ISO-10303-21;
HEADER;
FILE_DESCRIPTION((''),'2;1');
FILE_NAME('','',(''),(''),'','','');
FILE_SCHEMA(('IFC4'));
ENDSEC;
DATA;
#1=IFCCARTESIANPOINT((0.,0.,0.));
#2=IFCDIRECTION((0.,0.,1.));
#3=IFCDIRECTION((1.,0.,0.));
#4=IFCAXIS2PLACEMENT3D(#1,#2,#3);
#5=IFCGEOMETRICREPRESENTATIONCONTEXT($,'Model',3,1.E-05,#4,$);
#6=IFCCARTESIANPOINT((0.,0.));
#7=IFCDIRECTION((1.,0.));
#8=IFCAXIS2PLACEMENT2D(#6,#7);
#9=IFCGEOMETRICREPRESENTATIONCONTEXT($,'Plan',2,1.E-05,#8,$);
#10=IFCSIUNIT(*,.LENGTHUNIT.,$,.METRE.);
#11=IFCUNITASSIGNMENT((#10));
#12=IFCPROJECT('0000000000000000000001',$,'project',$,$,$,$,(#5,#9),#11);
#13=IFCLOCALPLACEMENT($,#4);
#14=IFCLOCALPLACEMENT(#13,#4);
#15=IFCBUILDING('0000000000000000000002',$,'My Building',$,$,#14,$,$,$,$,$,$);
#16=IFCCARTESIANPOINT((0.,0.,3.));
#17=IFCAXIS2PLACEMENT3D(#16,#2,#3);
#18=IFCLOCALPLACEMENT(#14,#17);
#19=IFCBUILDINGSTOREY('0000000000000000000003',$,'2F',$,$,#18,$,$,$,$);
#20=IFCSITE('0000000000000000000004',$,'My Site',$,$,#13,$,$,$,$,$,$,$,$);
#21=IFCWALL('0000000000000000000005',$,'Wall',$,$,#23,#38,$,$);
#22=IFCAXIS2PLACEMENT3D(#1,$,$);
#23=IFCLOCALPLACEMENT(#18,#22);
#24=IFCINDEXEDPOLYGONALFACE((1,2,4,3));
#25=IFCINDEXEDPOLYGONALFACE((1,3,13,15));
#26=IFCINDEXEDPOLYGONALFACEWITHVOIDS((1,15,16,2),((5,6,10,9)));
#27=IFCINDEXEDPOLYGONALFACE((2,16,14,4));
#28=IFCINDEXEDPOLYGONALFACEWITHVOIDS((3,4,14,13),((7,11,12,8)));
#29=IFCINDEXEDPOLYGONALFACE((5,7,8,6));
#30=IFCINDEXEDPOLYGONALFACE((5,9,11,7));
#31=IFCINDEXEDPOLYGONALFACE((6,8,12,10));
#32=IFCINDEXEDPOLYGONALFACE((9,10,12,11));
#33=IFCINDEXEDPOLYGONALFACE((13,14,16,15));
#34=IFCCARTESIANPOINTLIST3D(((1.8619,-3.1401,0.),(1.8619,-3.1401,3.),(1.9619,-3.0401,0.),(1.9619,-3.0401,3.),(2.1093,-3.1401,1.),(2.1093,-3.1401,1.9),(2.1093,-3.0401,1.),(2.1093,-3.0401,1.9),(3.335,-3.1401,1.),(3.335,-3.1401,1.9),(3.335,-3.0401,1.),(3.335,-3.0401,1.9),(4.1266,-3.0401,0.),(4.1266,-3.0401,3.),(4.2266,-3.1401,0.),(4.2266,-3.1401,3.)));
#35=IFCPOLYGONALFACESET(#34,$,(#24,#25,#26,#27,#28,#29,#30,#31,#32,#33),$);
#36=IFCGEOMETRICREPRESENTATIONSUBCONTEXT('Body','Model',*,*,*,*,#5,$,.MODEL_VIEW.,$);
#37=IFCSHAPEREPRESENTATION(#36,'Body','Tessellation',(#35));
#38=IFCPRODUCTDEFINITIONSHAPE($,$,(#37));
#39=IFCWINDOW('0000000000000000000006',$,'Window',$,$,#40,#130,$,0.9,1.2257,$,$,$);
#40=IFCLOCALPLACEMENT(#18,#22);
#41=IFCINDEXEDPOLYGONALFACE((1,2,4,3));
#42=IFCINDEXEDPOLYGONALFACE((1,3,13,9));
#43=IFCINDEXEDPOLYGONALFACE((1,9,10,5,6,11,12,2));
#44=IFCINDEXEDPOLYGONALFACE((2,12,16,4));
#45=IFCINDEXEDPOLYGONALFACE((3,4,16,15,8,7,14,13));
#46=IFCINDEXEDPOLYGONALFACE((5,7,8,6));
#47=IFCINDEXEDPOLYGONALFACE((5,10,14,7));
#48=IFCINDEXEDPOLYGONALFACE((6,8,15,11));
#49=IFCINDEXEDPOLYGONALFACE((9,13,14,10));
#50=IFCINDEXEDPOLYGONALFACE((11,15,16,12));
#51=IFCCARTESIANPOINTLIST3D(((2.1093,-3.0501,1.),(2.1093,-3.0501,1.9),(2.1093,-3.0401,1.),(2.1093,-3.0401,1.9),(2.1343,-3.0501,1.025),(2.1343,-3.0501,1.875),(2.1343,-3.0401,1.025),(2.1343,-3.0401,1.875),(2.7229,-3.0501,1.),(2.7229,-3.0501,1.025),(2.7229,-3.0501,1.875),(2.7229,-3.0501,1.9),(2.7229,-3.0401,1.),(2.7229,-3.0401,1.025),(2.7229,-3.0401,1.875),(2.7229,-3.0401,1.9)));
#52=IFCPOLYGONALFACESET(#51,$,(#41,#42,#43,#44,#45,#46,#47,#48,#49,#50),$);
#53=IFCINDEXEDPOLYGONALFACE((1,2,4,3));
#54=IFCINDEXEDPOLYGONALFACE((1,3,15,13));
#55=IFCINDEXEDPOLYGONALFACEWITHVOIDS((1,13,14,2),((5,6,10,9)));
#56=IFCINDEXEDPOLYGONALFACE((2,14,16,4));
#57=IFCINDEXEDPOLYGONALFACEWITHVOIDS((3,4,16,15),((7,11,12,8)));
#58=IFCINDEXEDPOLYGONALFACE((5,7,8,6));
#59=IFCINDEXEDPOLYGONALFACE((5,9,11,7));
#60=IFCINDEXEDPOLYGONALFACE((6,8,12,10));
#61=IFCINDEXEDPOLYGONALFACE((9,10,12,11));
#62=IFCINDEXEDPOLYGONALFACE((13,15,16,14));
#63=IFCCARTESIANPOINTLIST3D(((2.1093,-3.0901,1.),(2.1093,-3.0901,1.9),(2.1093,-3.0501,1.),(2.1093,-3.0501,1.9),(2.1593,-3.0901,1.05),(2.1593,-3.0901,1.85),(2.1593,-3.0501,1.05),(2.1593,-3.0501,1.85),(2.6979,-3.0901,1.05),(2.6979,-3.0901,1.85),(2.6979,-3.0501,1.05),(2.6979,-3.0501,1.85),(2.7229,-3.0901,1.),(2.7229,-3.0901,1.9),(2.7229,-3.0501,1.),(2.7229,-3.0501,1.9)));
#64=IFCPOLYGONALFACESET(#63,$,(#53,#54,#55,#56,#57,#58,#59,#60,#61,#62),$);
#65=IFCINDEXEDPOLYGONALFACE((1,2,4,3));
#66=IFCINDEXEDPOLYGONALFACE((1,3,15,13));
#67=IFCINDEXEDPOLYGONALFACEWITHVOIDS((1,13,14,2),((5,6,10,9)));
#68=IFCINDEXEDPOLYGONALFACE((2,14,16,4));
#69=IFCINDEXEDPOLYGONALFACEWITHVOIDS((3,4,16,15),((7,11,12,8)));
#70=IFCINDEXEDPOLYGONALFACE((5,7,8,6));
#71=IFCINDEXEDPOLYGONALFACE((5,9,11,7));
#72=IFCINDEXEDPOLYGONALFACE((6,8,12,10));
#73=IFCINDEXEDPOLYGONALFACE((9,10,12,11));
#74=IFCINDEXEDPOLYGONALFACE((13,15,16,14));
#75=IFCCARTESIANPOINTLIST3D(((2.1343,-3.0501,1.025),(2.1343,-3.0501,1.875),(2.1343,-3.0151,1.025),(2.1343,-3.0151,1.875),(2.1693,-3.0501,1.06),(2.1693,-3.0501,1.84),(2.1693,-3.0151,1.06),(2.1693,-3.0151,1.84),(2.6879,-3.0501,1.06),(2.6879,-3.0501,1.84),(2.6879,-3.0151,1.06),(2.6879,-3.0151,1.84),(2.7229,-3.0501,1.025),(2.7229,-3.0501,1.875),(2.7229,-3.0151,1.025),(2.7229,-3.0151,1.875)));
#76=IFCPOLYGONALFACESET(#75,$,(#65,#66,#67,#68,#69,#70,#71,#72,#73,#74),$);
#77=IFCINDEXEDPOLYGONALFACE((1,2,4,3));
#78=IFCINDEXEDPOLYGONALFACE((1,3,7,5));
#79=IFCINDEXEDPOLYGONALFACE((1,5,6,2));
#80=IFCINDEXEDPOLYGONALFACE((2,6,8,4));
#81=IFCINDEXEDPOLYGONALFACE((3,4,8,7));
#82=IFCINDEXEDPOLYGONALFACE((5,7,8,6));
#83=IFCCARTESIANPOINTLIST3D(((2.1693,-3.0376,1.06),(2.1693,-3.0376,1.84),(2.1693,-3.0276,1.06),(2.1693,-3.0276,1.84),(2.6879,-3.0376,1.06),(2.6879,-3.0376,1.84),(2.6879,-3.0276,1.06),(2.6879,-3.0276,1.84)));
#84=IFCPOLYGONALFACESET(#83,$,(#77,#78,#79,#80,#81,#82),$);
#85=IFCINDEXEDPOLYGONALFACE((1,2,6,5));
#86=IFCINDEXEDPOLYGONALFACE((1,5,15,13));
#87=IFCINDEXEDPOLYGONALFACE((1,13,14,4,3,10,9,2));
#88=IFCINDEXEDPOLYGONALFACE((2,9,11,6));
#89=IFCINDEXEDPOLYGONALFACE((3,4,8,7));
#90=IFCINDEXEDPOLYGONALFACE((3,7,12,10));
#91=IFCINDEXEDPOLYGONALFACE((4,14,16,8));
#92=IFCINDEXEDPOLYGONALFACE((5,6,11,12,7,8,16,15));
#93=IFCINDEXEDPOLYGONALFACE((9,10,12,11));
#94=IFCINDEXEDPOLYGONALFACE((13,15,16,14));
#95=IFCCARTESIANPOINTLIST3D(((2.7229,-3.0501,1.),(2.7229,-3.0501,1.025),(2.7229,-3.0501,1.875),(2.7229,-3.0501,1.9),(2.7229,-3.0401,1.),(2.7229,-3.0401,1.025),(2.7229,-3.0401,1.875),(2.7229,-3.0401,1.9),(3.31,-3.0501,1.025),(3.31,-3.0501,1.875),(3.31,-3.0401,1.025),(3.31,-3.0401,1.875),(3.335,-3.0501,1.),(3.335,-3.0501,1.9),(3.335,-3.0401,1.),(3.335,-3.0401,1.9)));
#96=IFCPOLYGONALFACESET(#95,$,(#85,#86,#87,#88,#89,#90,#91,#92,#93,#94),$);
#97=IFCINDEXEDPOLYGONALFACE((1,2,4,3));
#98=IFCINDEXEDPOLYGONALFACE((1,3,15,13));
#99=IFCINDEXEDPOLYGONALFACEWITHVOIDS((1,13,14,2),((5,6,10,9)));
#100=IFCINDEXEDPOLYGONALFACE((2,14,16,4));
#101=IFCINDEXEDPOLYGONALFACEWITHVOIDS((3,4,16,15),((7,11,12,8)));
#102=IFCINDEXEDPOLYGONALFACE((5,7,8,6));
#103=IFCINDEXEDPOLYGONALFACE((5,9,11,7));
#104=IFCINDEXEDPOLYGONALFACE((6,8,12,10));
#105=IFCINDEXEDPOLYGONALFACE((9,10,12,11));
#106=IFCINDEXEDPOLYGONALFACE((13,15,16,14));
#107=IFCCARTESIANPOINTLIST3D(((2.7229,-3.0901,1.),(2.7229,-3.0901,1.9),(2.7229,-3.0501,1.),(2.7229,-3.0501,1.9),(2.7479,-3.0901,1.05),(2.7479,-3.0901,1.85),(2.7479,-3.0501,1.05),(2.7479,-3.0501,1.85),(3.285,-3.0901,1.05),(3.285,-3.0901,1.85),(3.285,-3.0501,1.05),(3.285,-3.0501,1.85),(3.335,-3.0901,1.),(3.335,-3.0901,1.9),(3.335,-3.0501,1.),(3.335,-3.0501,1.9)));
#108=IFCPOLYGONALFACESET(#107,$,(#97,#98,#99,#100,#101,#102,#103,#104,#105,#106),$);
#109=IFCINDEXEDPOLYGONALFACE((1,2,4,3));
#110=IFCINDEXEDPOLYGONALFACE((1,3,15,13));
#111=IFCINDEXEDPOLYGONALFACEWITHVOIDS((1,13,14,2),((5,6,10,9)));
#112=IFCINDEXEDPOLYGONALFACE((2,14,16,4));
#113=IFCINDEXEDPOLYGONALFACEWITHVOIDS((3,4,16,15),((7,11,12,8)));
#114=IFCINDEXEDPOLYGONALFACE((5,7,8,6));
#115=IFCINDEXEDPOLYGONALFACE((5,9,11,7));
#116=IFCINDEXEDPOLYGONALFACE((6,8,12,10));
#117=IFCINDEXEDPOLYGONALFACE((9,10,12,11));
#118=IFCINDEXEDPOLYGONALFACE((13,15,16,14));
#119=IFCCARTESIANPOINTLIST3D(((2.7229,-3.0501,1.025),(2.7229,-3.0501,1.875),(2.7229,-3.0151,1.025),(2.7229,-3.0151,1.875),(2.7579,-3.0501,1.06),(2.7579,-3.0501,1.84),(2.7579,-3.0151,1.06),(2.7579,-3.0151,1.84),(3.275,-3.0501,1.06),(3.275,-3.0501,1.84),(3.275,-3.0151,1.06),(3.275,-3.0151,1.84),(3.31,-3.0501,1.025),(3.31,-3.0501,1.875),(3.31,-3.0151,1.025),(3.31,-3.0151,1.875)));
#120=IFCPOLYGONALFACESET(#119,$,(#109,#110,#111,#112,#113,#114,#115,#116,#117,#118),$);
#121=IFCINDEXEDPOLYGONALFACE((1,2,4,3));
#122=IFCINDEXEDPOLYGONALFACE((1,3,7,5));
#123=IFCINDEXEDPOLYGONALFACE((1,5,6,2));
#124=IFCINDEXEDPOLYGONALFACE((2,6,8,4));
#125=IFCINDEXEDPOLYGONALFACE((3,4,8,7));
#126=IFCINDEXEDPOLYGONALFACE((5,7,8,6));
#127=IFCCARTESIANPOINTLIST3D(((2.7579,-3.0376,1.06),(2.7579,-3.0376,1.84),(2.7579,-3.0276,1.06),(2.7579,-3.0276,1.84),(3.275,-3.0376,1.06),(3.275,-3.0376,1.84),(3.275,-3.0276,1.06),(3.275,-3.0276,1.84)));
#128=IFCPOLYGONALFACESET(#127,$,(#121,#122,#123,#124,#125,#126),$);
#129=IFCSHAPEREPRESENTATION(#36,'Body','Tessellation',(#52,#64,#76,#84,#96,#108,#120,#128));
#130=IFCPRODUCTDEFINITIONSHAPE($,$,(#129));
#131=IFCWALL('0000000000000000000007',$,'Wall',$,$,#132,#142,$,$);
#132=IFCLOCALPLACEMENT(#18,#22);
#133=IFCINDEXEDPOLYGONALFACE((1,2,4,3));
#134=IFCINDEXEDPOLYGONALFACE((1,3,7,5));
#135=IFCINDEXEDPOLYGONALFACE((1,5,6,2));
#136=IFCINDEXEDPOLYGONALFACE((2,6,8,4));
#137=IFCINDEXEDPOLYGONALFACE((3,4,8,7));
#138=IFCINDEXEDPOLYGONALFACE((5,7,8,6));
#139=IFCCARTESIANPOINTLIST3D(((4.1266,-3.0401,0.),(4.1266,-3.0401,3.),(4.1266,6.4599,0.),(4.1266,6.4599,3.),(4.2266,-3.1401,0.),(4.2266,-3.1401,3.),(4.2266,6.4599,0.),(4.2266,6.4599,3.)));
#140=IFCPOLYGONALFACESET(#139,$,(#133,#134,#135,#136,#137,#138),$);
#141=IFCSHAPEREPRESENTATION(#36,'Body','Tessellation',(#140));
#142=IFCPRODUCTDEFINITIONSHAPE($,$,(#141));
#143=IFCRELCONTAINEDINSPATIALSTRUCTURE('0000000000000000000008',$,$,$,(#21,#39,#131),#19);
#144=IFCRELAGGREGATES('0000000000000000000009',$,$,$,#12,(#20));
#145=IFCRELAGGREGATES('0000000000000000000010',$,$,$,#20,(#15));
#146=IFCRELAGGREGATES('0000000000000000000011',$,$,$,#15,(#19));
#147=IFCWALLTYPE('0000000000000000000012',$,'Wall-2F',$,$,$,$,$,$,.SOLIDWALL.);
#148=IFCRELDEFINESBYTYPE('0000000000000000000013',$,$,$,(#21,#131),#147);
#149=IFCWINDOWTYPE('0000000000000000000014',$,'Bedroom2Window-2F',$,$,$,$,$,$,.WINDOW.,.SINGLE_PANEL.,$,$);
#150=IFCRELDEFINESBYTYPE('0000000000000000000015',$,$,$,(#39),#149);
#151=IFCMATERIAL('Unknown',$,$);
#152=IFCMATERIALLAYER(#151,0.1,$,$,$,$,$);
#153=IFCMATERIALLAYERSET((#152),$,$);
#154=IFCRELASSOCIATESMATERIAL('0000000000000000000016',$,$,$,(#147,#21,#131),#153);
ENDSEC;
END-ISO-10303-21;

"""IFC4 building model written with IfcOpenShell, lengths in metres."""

from ifc_helpers import new_model, entity, si_unit, frame, origin_with_axes, origin_2d_with_axis, place, context, subcontext, project, spatial, line, indexed_curve, outline, extrude, shape, source, transform, mapped, material, layer, layer_set, layer_usage, type_object, type_shapes, element, fill, save


model = new_model("IFC4")

# Units and contexts
model_context = context("Model", 3, precision=1e-05, world=origin_with_axes())
plan_context = context("Plan", 2, precision=1e-05, world=origin_2d_with_axis())
body_context_1 = subcontext(model_context, "Body", "Model", "MODEL_VIEW")
body_context_2 = subcontext(plan_context, "Body", "Plan", "PLAN_VIEW")
ifc_project = project(units=[si_unit("LENGTHUNIT", "METRE")], contexts=[model_context, plan_context])

# Site, building, storey
site_placement = place(None, origin_with_axes())
site = spatial("IfcSite", under=ifc_project, at=site_placement, Name="My Site")
building_placement = place(site_placement, origin_with_axes())
building = spatial("IfcBuilding", under=site, at=building_placement, Name="My Building")
storey_placement = place(building_placement, frame((0.0, 0.0, 3.0), z_axis=(0.0, 0.0, 1.0), x_axis=(1.0, 0.0, 0.0)))
storey = spatial("IfcBuildingStorey", under=building, at=storey_placement, Name="2F")

# Shared definitions
ifc_material = material(Name="Unknown")

# Shared definitions
ifc_layer_1 = layer(ifc_material, 0.1)
ifc_layer_set_1 = layer_set([ifc_layer_1])
wall_type_1 = type_object("IfcWallType", Name="Wall-2F", PredefinedType="SOLIDWALL", material=ifc_layer_set_1)

# Wall, opening, window
ifc_layer_usage_1 = layer_usage(ifc_layer_set_1, "AXIS2", "POSITIVE", 0.0)
wall_1_placement = place(storey_placement, frame((1.8619, -3.1401, 0.0), z_axis=(0.0, 0.0, 1.0), x_axis=(1.0, 0.0, 0.0)))
wall_1 = element("IfcWall", 1, at=wall_1_placement, inside=storey, type_object=wall_type_1, material=ifc_layer_usage_1, Name="Wall", context=body_context_1, shape_type="SweptSolid", body=[
    extrude(outline(indexed_curve([(0.0, 0.0), (0.1, 0.1), (2.2647, 0.1), (2.3647, 0.0)], segments=[line(1, 2, 3, 4, 1)])), origin_with_axes(), (0.0, 0.0, 1.0), 3.0),
])
shared_shape_1 = source(origin_with_axes(), body_context_1, "Body", "SweptSolid", [
    extrude(outline(indexed_curve([(0.0, 0.0), (1.2257, 0.0), (1.2257, 0.9), (0.0, 0.9)], segments=[line(1, 2, 3, 4, 1)])), frame((0.0, -0.6, 0.0), z_axis=(0.0, -1.0, 0.0), x_axis=(1.0, 0.0, 0.0)), (0.0, 0.0, -1.0), 1.2),
])
opening_1_placement = place(wall_1_placement, frame((0.2474, 0.0, 1.0), z_axis=(0.0, 0.0, 1.0), x_axis=(1.0, 0.0, 0.0)))
opening_1 = element("IfcOpeningElement", 2, at=opening_1_placement, cuts=wall_1, PredefinedType="OPENING", context=body_context_1, shape_type="MappedRepresentation", body=[
    mapped(shared_shape_1, transform((0.0, 0.0, 0.0), x_axis=(1.0, 0.0, 0.0), y_axis=(0.0, 1.0, 0.0), z_axis=(0.0, 0.0, 1.0), scale=1.0)),
])
window_type = type_object("IfcWindowType", Name="Bedroom2Window-2F", PartitioningType="SINGLE_PANEL", PredefinedType="WINDOW")
shared_shape_2 = source(origin_with_axes(), body_context_1, "Body", "SweptSolid", [
    extrude(outline(indexed_curve([(0.6136, 0.0), (0.0, 0.0), (0.0, 0.9), (0.6136, 0.9), (0.6136, 0.875), (0.025, 0.875), (0.025, 0.025), (0.6136, 0.025)], segments=[line(1, 2, 3, 4, 5, 6, 7, 8, 1)])), frame((0.0, 0.09, 0.0), z_axis=(0.0, -1.0, 0.0), x_axis=(1.0, 0.0, 0.0)), (0.0, 0.0, -1.0), 0.01),
    extrude(outline(indexed_curve([(0.0, 0.0), (0.6136, 0.0), (0.6136, 0.9), (0.0, 0.9)], segments=[line(1, 2, 3, 4, 1)]), holes=[indexed_curve([(0.05, 0.05), (0.5886, 0.05), (0.5886, 0.85), (0.05, 0.85)], segments=[line(1, 2, 3, 4, 1)])]), frame((0.0, 0.05, 0.0), z_axis=(0.0, -1.0, 0.0), x_axis=(1.0, 0.0, 0.0)), (0.0, 0.0, -1.0), 0.04),
    extrude(outline(indexed_curve([(0.0, 0.0), (0.5886, 0.0), (0.5886, 0.85), (0.0, 0.85)], segments=[line(1, 2, 3, 4, 1)]), holes=[indexed_curve([(0.035, 0.035), (0.5536, 0.035), (0.5536, 0.815), (0.035, 0.815)], segments=[line(1, 2, 3, 4, 1)])]), frame((0.025, 0.09, 0.025), z_axis=(0.0, -1.0, 0.0), x_axis=(1.0, 0.0, 0.0)), (0.0, 0.0, -1.0), 0.035),
    extrude(outline(indexed_curve([(0.035, 0.035), (0.5536, 0.035), (0.5536, 0.815), (0.035, 0.815)], segments=[line(1, 2, 3, 4, 1)])), frame((0.025, 0.1025, 0.025), z_axis=(0.0, -1.0, 0.0), x_axis=(1.0, 0.0, 0.0)), (0.0, 0.0, -1.0), 0.01),
    extrude(outline(indexed_curve([(0.0, 0.9), (0.6121, 0.9), (0.6121, 0.0), (0.0, 0.0), (0.0, 0.025), (0.5871, 0.025), (0.5871, 0.875), (0.0, 0.875)], segments=[line(1, 2, 3, 4, 5, 6, 7, 8, 1)])), frame((0.6136, 0.09, 0.0), z_axis=(0.0, -1.0, 0.0), x_axis=(1.0, 0.0, 0.0)), (0.0, 0.0, -1.0), 0.01),
    extrude(outline(indexed_curve([(0.0, 0.0), (0.6121, 0.0), (0.6121, 0.9), (0.0, 0.9)], segments=[line(1, 2, 3, 4, 1)]), holes=[indexed_curve([(0.025, 0.05), (0.5621, 0.05), (0.5621, 0.85), (0.025, 0.85)], segments=[line(1, 2, 3, 4, 1)])]), frame((0.6136, 0.05, 0.0), z_axis=(0.0, -1.0, 0.0), x_axis=(1.0, 0.0, 0.0)), (0.0, 0.0, -1.0), 0.04),
    extrude(outline(indexed_curve([(0.0, 0.0), (0.5871, 0.0), (0.5871, 0.85), (0.0, 0.85)], segments=[line(1, 2, 3, 4, 1)]), holes=[indexed_curve([(0.035, 0.035), (0.5521, 0.035), (0.5521, 0.815), (0.035, 0.815)], segments=[line(1, 2, 3, 4, 1)])]), frame((0.6136, 0.09, 0.025), z_axis=(0.0, -1.0, 0.0), x_axis=(1.0, 0.0, 0.0)), (0.0, 0.0, -1.0), 0.035),
    extrude(outline(indexed_curve([(0.035, 0.035), (0.5521, 0.035), (0.5521, 0.815), (0.035, 0.815)], segments=[line(1, 2, 3, 4, 1)])), frame((0.6136, 0.1025, 0.025), z_axis=(0.0, -1.0, 0.0), x_axis=(1.0, 0.0, 0.0)), (0.0, 0.0, -1.0), 0.01),
])
shared_shape_3 = source(origin_with_axes(), body_context_2, "Body", "Curve2D", [
    entity("IfcIndexedPolyCurve", entity("IfcCartesianPointList2D", [[0.05, 0.05], [0.5886, 0.05]])),
    entity("IfcIndexedPolyCurve", entity("IfcCartesianPointList2D", [[0.0, 0.1], [0.025, 0.1], [0.025, 0.09], [0.05, 0.09], [0.05, 0.05], [0.0, 0.05]]), [entity("IfcLineIndex", [1, 2, 3, 4, 5, 6, 1])]),
    entity("IfcIndexedPolyCurve", entity("IfcCartesianPointList2D", [[0.6136, 0.1], [0.6136, 0.1], [0.6136, 0.09], [0.5886, 0.09], [0.5886, 0.05], [0.6136, 0.05]])),
    entity("IfcIndexedPolyCurve", entity("IfcCartesianPointList2D", [[0.025, 0.09], [0.06, 0.09], [0.06, 0.125], [0.025, 0.125]]), [entity("IfcLineIndex", [1, 2, 3, 4, 1])]),
    entity("IfcIndexedPolyCurve", entity("IfcCartesianPointList2D", [[0.6136, 0.09], [0.5786, 0.09], [0.5786, 0.125], [0.6136, 0.125]]), [entity("IfcLineIndex", [1, 2, 3, 4, 1])]),
    entity("IfcIndexedPolyCurve", entity("IfcCartesianPointList2D", [[0.06, 0.09], [0.5786, 0.09]])),
    entity("IfcIndexedPolyCurve", entity("IfcCartesianPointList2D", [[0.06, 0.125], [0.5786, 0.125]])),
    entity("IfcIndexedPolyCurve", entity("IfcCartesianPointList2D", [[0.06, 0.1075], [0.5786, 0.1075]])),
    entity("IfcIndexedPolyCurve", entity("IfcCartesianPointList2D", [[0.6386, 0.05], [1.1757, 0.05]])),
    entity("IfcIndexedPolyCurve", entity("IfcCartesianPointList2D", [[0.6136, 0.1], [0.6136, 0.1], [0.6136, 0.09], [0.6386, 0.09], [0.6386, 0.05], [0.6136, 0.05]])),
    entity("IfcIndexedPolyCurve", entity("IfcCartesianPointList2D", [[1.2257, 0.1], [1.2007, 0.1], [1.2007, 0.09], [1.1757, 0.09], [1.1757, 0.05], [1.2257, 0.05]]), [entity("IfcLineIndex", [1, 2, 3, 4, 5, 6, 1])]),
    entity("IfcIndexedPolyCurve", entity("IfcCartesianPointList2D", [[0.6136, 0.09], [0.6486, 0.09], [0.6486, 0.125], [0.6136, 0.125]]), [entity("IfcLineIndex", [1, 2, 3, 4, 1])]),
    entity("IfcIndexedPolyCurve", entity("IfcCartesianPointList2D", [[1.2007, 0.09], [1.1657, 0.09], [1.1657, 0.125], [1.2007, 0.125]]), [entity("IfcLineIndex", [1, 2, 3, 4, 1])]),
    entity("IfcIndexedPolyCurve", entity("IfcCartesianPointList2D", [[0.6486, 0.09], [1.1657, 0.09]])),
    entity("IfcIndexedPolyCurve", entity("IfcCartesianPointList2D", [[0.6486, 0.125], [1.1657, 0.125]])),
    entity("IfcIndexedPolyCurve", entity("IfcCartesianPointList2D", [[0.6486, 0.1075], [1.1657, 0.1075]])),
])
type_shapes(window_type, [shared_shape_2, shared_shape_3])
window_placement = place(opening_1_placement, origin_with_axes())
window = element("IfcWindow", 3, at=window_placement, inside=storey, type_object=window_type, Name="Window", OverallHeight=0.9, OverallWidth=1.2257, shapes=[
    shape(body_context_1, "Body", "MappedRepresentation", [mapped(shared_shape_2, transform((0.0, 0.0, 0.0), x_axis=(1.0, 0.0, 0.0), y_axis=(0.0, 1.0, 0.0), z_axis=(0.0, 0.0, 1.0), scale=1.0))]),
    shape(body_context_2, "Body", "MappedRepresentation", [mapped(shared_shape_3, transform((0.0, 0.0, 0.0), x_axis=(1.0, 0.0, 0.0), y_axis=(0.0, 1.0, 0.0), z_axis=(0.0, 0.0, 1.0), scale=1.0))]),
])
fill(opening_1, window)

# Wall
ifc_layer_usage_2 = layer_usage(ifc_layer_set_1, "AXIS2", "POSITIVE", 0.0)
wall_2_placement = place(storey_placement, frame((4.2266, -3.1401, 0.0), z_axis=(0.0, 0.0, 1.0), x_axis=(0.0, 1.0, 0.0)))
element("IfcWall", 4, at=wall_2_placement, inside=storey, type_object=wall_type_1, material=ifc_layer_usage_2, Name="Wall", context=body_context_1, shape_type="SweptSolid", body=[
    extrude(outline(indexed_curve([(0.0, 0.0), (0.1, 0.1), (9.6, 0.1), (9.6, 0.0)], segments=[line(1, 2, 3, 4, 1)])), origin_with_axes(), (0.0, 0.0, 1.0), 3.0),
])

save(model, "model.ifc")
